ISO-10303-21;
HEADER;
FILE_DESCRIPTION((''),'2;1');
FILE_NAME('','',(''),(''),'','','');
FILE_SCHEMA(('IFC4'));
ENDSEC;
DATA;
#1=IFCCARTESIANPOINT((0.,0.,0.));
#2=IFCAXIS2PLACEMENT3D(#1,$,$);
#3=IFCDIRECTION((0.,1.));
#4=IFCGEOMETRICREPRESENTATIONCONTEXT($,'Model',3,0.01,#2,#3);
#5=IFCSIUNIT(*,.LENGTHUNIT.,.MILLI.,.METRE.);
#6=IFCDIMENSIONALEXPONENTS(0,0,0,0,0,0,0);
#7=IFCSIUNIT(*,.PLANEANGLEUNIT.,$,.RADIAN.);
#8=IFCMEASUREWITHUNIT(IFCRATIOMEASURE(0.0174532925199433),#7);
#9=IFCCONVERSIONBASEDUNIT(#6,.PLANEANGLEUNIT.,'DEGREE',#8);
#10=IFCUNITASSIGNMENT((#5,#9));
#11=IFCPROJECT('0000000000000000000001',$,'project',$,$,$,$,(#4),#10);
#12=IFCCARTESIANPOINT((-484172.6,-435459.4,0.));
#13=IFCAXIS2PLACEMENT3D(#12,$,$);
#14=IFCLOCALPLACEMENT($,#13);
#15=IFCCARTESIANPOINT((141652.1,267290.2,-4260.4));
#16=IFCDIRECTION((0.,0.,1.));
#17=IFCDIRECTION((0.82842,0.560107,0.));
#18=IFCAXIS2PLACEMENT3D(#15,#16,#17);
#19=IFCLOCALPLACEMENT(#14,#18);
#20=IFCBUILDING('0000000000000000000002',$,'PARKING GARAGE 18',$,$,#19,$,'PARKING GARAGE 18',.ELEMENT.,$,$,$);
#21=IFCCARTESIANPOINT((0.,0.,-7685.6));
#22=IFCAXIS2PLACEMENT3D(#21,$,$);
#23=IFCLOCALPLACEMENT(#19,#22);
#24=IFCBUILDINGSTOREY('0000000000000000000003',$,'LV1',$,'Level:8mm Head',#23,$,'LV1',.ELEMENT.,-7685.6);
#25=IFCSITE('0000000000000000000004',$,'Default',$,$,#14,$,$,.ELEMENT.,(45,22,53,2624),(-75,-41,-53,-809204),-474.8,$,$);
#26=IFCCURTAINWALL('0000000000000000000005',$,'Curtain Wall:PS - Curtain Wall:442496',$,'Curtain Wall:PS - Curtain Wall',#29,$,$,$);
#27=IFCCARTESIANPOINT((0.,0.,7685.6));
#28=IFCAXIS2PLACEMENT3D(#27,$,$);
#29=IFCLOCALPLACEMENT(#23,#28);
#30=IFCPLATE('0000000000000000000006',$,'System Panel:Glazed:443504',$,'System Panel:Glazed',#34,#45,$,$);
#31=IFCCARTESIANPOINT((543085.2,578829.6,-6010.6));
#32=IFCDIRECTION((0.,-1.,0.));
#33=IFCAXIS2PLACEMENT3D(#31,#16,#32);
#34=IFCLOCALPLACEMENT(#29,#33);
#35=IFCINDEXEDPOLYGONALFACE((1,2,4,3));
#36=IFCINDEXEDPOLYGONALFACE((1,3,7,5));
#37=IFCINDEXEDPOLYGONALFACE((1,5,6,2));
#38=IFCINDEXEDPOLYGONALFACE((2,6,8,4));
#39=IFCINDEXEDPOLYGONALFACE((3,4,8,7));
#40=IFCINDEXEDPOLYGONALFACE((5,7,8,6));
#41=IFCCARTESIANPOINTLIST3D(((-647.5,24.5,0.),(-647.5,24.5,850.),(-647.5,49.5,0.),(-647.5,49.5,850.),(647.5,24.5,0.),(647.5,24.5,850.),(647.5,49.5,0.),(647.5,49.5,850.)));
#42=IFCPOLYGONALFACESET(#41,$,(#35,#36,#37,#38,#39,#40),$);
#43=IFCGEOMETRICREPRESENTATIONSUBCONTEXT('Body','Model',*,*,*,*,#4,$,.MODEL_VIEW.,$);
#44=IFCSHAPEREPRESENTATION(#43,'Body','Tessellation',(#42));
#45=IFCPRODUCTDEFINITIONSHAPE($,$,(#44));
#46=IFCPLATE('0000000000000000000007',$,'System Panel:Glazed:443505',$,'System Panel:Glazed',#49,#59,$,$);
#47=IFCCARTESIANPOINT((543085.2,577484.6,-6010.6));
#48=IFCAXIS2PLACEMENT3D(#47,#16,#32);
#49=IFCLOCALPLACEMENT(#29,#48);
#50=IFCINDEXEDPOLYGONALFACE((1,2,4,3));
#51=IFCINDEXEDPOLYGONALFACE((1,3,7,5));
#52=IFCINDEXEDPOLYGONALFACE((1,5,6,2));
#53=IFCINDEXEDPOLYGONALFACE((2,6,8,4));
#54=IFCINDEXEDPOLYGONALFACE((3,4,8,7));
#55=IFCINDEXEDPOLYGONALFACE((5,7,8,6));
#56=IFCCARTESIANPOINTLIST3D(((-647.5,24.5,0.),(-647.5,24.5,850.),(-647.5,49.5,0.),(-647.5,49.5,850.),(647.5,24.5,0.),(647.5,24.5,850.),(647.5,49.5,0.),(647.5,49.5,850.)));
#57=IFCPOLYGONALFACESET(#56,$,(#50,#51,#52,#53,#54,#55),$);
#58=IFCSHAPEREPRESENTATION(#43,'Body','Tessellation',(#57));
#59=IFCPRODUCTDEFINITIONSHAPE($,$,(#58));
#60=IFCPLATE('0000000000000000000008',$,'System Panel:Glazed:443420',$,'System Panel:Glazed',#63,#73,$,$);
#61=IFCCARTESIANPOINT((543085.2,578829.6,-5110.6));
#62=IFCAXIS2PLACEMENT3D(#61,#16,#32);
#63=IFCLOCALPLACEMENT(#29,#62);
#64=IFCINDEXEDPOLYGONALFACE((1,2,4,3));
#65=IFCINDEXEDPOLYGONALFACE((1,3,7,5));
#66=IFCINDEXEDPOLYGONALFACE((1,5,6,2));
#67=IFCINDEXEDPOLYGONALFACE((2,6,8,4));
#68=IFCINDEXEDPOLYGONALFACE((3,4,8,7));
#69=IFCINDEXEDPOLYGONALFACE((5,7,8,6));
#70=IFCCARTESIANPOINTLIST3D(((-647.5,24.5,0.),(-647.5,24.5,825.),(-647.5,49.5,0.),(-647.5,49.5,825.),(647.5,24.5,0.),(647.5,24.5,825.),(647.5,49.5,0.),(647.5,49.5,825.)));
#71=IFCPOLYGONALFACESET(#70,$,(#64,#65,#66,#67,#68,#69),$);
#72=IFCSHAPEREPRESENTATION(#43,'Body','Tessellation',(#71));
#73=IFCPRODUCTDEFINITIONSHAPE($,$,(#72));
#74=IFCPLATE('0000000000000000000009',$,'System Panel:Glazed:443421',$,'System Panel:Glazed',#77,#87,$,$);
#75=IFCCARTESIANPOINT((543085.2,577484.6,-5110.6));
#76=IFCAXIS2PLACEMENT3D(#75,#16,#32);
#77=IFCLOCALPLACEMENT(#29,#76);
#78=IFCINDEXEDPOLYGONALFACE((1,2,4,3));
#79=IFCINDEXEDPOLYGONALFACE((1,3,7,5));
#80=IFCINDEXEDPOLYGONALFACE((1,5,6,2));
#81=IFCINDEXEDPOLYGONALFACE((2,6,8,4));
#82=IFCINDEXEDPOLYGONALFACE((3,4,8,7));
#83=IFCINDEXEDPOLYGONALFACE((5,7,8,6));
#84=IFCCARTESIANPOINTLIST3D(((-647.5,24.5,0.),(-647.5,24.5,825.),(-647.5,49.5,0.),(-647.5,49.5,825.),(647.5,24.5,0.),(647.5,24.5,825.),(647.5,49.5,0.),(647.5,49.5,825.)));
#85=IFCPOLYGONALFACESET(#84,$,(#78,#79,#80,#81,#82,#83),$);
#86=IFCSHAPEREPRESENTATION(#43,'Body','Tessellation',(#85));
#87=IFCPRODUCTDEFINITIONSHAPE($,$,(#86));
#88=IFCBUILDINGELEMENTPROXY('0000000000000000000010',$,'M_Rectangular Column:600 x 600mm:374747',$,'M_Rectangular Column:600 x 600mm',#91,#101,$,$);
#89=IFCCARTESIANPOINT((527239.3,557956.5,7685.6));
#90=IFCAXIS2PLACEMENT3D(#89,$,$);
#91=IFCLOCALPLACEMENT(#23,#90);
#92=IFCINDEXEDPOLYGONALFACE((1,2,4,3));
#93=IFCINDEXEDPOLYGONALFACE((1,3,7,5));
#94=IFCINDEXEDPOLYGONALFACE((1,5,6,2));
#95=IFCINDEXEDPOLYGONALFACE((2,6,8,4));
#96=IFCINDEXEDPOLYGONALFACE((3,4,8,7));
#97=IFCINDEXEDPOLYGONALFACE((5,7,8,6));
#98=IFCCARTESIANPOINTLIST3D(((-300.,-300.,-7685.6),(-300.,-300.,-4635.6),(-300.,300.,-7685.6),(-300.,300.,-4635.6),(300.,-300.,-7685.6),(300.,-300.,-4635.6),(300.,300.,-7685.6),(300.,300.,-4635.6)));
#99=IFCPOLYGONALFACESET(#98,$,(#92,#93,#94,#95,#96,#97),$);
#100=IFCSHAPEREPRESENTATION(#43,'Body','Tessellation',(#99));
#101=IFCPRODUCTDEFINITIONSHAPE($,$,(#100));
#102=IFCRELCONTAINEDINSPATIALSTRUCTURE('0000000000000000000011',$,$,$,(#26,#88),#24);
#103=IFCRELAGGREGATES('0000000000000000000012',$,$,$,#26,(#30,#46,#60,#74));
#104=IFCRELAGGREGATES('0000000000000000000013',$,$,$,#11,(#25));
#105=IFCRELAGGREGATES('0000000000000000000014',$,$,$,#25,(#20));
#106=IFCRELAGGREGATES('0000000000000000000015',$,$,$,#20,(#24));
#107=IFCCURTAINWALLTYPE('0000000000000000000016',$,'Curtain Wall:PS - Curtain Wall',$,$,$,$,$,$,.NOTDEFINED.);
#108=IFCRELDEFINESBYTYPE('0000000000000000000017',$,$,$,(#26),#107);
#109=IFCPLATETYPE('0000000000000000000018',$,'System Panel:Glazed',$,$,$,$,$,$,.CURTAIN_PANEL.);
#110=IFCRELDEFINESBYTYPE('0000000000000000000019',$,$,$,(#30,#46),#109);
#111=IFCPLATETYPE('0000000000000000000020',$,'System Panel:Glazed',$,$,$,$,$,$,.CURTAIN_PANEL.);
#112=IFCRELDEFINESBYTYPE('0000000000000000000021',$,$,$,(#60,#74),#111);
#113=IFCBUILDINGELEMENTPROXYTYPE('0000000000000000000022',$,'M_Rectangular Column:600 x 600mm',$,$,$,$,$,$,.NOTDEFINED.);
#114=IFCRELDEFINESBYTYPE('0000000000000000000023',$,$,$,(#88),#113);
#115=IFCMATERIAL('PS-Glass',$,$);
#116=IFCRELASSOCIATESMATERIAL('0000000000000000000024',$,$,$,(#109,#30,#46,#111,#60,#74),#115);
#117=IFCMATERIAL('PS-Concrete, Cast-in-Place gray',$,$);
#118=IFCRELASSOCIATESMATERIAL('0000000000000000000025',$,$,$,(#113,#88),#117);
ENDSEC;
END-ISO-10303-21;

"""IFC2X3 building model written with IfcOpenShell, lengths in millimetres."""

from ifc_helpers import new_model, entity, si_unit, converted_unit, direction, frame, origin, origin_2d_with_axis, place, context, subcontext, project, spatial, rectangle, extrude, source, transform, mapped, material, type_object, type_shapes, element, aggregate, save


model = new_model("IFC2X3")

# Units and contexts
model_context = context("Model", 3, precision=0.01, world=origin(), true_north=direction((0.0, 1.0)))
body_context = subcontext(model_context, "Body", "Model", "MODEL_VIEW")
ifc_project = project(units=[si_unit("LENGTHUNIT", "METRE", prefix="MILLI"), converted_unit("PLANEANGLEUNIT", "DEGREE", entity("IfcRatioMeasure", 0.0174532925199433), si_unit("PLANEANGLEUNIT", "RADIAN"), dimensions=[0, 0, 0, 0, 0, 0, 0])], contexts=[model_context])

# Site, building, storey
site_placement = place(None, frame((-484172.6, -435459.4, 0.0)))
site = spatial("IfcSite", under=ifc_project, at=site_placement, Name="Default", CompositionType="ELEMENT", RefLatitude=(45, 22, 53, 2624), RefLongitude=(-75, -41, -53, -809204), RefElevation=-474.8)
building_placement = place(site_placement, frame((141652.1, 267290.2, -4260.4), z_axis=(0.0, 0.0, 1.0), x_axis=(0.82842, 0.560107, 0.0)))
building = spatial("IfcBuilding", under=site, at=building_placement, Name="PARKING GARAGE 18", LongName="PARKING GARAGE 18", CompositionType="ELEMENT")
storey_placement = place(building_placement, frame((0.0, 0.0, -7685.6)))
storey = spatial("IfcBuildingStorey", under=building, at=storey_placement, Name="LV1", ObjectType="Level:8mm Head", LongName="LV1", CompositionType="ELEMENT", Elevation=-7685.6)

# Curtain wall, plates
curtain_wall_type = type_object("IfcCurtainWallType", Name="Curtain Wall:PS - Curtain Wall", PredefinedType="NOTDEFINED")
ifc_material_1 = material(Name="PS-Glass")
curtain_wall_1_placement = place(storey_placement, frame((0.0, 0.0, 7685.6)))
curtain_wall_1 = element("IfcCurtainWall", 1, at=curtain_wall_1_placement, inside=storey, type_object=curtain_wall_type, Name="Curtain Wall:PS - Curtain Wall:442496", ObjectType="Curtain Wall:PS - Curtain Wall")
plate_type_1 = type_object("IfcPlateType", Name="System Panel:Glazed", PredefinedType="CURTAIN_PANEL", material=ifc_material_1)
shared_shape_1 = source(origin(), body_context, "Body", "SweptSolid", [
    extrude(rectangle(XDim=25.0, YDim=1295.0, at=origin_2d_with_axis()), frame((0.0, 37.0, 0.0), z_axis=(0.0, 0.0, 1.0), x_axis=(0.0, 1.0, 0.0)), (0.0, 0.0, 1.0), 850.0),
])
type_shapes(plate_type_1, [shared_shape_1])
plate_1_placement = place(curtain_wall_1_placement, frame((543085.2, 578829.6, -6010.6), z_axis=(0.0, 0.0, 1.0), x_axis=(0.0, -1.0, 0.0)))
plate_1 = element("IfcPlate", 2, at=plate_1_placement, type_object=plate_type_1, material=ifc_material_1, Name="System Panel:Glazed:443504", ObjectType="System Panel:Glazed", context=body_context, shape_type="MappedRepresentation", body=[
    mapped(shared_shape_1, transform((0.0, 0.0, 0.0), scale=1.0)),
])
plate_2_placement = place(curtain_wall_1_placement, frame((543085.2, 577484.6, -6010.6), z_axis=(0.0, 0.0, 1.0), x_axis=(0.0, -1.0, 0.0)))
plate_2 = element("IfcPlate", 3, at=plate_2_placement, type_object=plate_type_1, material=ifc_material_1, Name="System Panel:Glazed:443505", ObjectType="System Panel:Glazed", context=body_context, shape_type="MappedRepresentation", body=[
    mapped(shared_shape_1, transform((0.0, 0.0, 0.0), scale=1.0)),
])
plate_type_2 = type_object("IfcPlateType", Name="System Panel:Glazed", PredefinedType="CURTAIN_PANEL", material=ifc_material_1)
shared_shape_2 = source(origin(), body_context, "Body", "SweptSolid", [
    extrude(rectangle(XDim=25.0, YDim=1295.0, at=origin_2d_with_axis()), frame((0.0, 37.0, 0.0), z_axis=(0.0, 0.0, 1.0), x_axis=(0.0, 1.0, 0.0)), (0.0, 0.0, 1.0), 825.0),
])
type_shapes(plate_type_2, [shared_shape_2])
plate_3_placement = place(curtain_wall_1_placement, frame((543085.2, 578829.6, -5110.6), z_axis=(0.0, 0.0, 1.0), x_axis=(0.0, -1.0, 0.0)))
plate_3 = element("IfcPlate", 4, at=plate_3_placement, type_object=plate_type_2, material=ifc_material_1, Name="System Panel:Glazed:443420", ObjectType="System Panel:Glazed", context=body_context, shape_type="MappedRepresentation", body=[
    mapped(shared_shape_2, transform((0.0, 0.0, 0.0), scale=1.0)),
])
plate_4_placement = place(curtain_wall_1_placement, frame((543085.2, 577484.6, -5110.6), z_axis=(0.0, 0.0, 1.0), x_axis=(0.0, -1.0, 0.0)))
plate_4 = element("IfcPlate", 5, at=plate_4_placement, type_object=plate_type_2, material=ifc_material_1, Name="System Panel:Glazed:443421", ObjectType="System Panel:Glazed", context=body_context, shape_type="MappedRepresentation", body=[
    mapped(shared_shape_2, transform((0.0, 0.0, 0.0), scale=1.0)),
])
aggregate(curtain_wall_1, [plate_1, plate_2, plate_3, plate_4])

# Building element proxy
ifc_material_2 = material(Name="PS-Concrete, Cast-in-Place gray")
building_element_proxy_type = type_object("IfcBuildingElementProxyType", Name="M_Rectangular Column:600 x 600mm", PredefinedType="NOTDEFINED", material=ifc_material_2)
shared_shape_3 = source(origin(), body_context, "Body", "SweptSolid", [
    extrude(rectangle(XDim=600.0, YDim=600.0, at=origin_2d_with_axis()), frame((0.0, 0.0, -7685.6), z_axis=(0.0, 0.0, 1.0), x_axis=(0.0, 1.0, 0.0)), (0.0, 0.0, 1.0), 3050.0),
])
type_shapes(building_element_proxy_type, [shared_shape_3])
proxy_placement = place(storey_placement, frame((527239.3, 557956.5, 7685.6)))
element("IfcBuildingElementProxy", 6, at=proxy_placement, inside=storey, type_object=building_element_proxy_type, material=ifc_material_2, Name="M_Rectangular Column:600 x 600mm:374747", ObjectType="M_Rectangular Column:600 x 600mm", context=body_context, shape_type="MappedRepresentation", body=[
    mapped(shared_shape_3, transform((0.0, 0.0, 0.0), scale=1.0)),
])

save(model, "model.ifc")
